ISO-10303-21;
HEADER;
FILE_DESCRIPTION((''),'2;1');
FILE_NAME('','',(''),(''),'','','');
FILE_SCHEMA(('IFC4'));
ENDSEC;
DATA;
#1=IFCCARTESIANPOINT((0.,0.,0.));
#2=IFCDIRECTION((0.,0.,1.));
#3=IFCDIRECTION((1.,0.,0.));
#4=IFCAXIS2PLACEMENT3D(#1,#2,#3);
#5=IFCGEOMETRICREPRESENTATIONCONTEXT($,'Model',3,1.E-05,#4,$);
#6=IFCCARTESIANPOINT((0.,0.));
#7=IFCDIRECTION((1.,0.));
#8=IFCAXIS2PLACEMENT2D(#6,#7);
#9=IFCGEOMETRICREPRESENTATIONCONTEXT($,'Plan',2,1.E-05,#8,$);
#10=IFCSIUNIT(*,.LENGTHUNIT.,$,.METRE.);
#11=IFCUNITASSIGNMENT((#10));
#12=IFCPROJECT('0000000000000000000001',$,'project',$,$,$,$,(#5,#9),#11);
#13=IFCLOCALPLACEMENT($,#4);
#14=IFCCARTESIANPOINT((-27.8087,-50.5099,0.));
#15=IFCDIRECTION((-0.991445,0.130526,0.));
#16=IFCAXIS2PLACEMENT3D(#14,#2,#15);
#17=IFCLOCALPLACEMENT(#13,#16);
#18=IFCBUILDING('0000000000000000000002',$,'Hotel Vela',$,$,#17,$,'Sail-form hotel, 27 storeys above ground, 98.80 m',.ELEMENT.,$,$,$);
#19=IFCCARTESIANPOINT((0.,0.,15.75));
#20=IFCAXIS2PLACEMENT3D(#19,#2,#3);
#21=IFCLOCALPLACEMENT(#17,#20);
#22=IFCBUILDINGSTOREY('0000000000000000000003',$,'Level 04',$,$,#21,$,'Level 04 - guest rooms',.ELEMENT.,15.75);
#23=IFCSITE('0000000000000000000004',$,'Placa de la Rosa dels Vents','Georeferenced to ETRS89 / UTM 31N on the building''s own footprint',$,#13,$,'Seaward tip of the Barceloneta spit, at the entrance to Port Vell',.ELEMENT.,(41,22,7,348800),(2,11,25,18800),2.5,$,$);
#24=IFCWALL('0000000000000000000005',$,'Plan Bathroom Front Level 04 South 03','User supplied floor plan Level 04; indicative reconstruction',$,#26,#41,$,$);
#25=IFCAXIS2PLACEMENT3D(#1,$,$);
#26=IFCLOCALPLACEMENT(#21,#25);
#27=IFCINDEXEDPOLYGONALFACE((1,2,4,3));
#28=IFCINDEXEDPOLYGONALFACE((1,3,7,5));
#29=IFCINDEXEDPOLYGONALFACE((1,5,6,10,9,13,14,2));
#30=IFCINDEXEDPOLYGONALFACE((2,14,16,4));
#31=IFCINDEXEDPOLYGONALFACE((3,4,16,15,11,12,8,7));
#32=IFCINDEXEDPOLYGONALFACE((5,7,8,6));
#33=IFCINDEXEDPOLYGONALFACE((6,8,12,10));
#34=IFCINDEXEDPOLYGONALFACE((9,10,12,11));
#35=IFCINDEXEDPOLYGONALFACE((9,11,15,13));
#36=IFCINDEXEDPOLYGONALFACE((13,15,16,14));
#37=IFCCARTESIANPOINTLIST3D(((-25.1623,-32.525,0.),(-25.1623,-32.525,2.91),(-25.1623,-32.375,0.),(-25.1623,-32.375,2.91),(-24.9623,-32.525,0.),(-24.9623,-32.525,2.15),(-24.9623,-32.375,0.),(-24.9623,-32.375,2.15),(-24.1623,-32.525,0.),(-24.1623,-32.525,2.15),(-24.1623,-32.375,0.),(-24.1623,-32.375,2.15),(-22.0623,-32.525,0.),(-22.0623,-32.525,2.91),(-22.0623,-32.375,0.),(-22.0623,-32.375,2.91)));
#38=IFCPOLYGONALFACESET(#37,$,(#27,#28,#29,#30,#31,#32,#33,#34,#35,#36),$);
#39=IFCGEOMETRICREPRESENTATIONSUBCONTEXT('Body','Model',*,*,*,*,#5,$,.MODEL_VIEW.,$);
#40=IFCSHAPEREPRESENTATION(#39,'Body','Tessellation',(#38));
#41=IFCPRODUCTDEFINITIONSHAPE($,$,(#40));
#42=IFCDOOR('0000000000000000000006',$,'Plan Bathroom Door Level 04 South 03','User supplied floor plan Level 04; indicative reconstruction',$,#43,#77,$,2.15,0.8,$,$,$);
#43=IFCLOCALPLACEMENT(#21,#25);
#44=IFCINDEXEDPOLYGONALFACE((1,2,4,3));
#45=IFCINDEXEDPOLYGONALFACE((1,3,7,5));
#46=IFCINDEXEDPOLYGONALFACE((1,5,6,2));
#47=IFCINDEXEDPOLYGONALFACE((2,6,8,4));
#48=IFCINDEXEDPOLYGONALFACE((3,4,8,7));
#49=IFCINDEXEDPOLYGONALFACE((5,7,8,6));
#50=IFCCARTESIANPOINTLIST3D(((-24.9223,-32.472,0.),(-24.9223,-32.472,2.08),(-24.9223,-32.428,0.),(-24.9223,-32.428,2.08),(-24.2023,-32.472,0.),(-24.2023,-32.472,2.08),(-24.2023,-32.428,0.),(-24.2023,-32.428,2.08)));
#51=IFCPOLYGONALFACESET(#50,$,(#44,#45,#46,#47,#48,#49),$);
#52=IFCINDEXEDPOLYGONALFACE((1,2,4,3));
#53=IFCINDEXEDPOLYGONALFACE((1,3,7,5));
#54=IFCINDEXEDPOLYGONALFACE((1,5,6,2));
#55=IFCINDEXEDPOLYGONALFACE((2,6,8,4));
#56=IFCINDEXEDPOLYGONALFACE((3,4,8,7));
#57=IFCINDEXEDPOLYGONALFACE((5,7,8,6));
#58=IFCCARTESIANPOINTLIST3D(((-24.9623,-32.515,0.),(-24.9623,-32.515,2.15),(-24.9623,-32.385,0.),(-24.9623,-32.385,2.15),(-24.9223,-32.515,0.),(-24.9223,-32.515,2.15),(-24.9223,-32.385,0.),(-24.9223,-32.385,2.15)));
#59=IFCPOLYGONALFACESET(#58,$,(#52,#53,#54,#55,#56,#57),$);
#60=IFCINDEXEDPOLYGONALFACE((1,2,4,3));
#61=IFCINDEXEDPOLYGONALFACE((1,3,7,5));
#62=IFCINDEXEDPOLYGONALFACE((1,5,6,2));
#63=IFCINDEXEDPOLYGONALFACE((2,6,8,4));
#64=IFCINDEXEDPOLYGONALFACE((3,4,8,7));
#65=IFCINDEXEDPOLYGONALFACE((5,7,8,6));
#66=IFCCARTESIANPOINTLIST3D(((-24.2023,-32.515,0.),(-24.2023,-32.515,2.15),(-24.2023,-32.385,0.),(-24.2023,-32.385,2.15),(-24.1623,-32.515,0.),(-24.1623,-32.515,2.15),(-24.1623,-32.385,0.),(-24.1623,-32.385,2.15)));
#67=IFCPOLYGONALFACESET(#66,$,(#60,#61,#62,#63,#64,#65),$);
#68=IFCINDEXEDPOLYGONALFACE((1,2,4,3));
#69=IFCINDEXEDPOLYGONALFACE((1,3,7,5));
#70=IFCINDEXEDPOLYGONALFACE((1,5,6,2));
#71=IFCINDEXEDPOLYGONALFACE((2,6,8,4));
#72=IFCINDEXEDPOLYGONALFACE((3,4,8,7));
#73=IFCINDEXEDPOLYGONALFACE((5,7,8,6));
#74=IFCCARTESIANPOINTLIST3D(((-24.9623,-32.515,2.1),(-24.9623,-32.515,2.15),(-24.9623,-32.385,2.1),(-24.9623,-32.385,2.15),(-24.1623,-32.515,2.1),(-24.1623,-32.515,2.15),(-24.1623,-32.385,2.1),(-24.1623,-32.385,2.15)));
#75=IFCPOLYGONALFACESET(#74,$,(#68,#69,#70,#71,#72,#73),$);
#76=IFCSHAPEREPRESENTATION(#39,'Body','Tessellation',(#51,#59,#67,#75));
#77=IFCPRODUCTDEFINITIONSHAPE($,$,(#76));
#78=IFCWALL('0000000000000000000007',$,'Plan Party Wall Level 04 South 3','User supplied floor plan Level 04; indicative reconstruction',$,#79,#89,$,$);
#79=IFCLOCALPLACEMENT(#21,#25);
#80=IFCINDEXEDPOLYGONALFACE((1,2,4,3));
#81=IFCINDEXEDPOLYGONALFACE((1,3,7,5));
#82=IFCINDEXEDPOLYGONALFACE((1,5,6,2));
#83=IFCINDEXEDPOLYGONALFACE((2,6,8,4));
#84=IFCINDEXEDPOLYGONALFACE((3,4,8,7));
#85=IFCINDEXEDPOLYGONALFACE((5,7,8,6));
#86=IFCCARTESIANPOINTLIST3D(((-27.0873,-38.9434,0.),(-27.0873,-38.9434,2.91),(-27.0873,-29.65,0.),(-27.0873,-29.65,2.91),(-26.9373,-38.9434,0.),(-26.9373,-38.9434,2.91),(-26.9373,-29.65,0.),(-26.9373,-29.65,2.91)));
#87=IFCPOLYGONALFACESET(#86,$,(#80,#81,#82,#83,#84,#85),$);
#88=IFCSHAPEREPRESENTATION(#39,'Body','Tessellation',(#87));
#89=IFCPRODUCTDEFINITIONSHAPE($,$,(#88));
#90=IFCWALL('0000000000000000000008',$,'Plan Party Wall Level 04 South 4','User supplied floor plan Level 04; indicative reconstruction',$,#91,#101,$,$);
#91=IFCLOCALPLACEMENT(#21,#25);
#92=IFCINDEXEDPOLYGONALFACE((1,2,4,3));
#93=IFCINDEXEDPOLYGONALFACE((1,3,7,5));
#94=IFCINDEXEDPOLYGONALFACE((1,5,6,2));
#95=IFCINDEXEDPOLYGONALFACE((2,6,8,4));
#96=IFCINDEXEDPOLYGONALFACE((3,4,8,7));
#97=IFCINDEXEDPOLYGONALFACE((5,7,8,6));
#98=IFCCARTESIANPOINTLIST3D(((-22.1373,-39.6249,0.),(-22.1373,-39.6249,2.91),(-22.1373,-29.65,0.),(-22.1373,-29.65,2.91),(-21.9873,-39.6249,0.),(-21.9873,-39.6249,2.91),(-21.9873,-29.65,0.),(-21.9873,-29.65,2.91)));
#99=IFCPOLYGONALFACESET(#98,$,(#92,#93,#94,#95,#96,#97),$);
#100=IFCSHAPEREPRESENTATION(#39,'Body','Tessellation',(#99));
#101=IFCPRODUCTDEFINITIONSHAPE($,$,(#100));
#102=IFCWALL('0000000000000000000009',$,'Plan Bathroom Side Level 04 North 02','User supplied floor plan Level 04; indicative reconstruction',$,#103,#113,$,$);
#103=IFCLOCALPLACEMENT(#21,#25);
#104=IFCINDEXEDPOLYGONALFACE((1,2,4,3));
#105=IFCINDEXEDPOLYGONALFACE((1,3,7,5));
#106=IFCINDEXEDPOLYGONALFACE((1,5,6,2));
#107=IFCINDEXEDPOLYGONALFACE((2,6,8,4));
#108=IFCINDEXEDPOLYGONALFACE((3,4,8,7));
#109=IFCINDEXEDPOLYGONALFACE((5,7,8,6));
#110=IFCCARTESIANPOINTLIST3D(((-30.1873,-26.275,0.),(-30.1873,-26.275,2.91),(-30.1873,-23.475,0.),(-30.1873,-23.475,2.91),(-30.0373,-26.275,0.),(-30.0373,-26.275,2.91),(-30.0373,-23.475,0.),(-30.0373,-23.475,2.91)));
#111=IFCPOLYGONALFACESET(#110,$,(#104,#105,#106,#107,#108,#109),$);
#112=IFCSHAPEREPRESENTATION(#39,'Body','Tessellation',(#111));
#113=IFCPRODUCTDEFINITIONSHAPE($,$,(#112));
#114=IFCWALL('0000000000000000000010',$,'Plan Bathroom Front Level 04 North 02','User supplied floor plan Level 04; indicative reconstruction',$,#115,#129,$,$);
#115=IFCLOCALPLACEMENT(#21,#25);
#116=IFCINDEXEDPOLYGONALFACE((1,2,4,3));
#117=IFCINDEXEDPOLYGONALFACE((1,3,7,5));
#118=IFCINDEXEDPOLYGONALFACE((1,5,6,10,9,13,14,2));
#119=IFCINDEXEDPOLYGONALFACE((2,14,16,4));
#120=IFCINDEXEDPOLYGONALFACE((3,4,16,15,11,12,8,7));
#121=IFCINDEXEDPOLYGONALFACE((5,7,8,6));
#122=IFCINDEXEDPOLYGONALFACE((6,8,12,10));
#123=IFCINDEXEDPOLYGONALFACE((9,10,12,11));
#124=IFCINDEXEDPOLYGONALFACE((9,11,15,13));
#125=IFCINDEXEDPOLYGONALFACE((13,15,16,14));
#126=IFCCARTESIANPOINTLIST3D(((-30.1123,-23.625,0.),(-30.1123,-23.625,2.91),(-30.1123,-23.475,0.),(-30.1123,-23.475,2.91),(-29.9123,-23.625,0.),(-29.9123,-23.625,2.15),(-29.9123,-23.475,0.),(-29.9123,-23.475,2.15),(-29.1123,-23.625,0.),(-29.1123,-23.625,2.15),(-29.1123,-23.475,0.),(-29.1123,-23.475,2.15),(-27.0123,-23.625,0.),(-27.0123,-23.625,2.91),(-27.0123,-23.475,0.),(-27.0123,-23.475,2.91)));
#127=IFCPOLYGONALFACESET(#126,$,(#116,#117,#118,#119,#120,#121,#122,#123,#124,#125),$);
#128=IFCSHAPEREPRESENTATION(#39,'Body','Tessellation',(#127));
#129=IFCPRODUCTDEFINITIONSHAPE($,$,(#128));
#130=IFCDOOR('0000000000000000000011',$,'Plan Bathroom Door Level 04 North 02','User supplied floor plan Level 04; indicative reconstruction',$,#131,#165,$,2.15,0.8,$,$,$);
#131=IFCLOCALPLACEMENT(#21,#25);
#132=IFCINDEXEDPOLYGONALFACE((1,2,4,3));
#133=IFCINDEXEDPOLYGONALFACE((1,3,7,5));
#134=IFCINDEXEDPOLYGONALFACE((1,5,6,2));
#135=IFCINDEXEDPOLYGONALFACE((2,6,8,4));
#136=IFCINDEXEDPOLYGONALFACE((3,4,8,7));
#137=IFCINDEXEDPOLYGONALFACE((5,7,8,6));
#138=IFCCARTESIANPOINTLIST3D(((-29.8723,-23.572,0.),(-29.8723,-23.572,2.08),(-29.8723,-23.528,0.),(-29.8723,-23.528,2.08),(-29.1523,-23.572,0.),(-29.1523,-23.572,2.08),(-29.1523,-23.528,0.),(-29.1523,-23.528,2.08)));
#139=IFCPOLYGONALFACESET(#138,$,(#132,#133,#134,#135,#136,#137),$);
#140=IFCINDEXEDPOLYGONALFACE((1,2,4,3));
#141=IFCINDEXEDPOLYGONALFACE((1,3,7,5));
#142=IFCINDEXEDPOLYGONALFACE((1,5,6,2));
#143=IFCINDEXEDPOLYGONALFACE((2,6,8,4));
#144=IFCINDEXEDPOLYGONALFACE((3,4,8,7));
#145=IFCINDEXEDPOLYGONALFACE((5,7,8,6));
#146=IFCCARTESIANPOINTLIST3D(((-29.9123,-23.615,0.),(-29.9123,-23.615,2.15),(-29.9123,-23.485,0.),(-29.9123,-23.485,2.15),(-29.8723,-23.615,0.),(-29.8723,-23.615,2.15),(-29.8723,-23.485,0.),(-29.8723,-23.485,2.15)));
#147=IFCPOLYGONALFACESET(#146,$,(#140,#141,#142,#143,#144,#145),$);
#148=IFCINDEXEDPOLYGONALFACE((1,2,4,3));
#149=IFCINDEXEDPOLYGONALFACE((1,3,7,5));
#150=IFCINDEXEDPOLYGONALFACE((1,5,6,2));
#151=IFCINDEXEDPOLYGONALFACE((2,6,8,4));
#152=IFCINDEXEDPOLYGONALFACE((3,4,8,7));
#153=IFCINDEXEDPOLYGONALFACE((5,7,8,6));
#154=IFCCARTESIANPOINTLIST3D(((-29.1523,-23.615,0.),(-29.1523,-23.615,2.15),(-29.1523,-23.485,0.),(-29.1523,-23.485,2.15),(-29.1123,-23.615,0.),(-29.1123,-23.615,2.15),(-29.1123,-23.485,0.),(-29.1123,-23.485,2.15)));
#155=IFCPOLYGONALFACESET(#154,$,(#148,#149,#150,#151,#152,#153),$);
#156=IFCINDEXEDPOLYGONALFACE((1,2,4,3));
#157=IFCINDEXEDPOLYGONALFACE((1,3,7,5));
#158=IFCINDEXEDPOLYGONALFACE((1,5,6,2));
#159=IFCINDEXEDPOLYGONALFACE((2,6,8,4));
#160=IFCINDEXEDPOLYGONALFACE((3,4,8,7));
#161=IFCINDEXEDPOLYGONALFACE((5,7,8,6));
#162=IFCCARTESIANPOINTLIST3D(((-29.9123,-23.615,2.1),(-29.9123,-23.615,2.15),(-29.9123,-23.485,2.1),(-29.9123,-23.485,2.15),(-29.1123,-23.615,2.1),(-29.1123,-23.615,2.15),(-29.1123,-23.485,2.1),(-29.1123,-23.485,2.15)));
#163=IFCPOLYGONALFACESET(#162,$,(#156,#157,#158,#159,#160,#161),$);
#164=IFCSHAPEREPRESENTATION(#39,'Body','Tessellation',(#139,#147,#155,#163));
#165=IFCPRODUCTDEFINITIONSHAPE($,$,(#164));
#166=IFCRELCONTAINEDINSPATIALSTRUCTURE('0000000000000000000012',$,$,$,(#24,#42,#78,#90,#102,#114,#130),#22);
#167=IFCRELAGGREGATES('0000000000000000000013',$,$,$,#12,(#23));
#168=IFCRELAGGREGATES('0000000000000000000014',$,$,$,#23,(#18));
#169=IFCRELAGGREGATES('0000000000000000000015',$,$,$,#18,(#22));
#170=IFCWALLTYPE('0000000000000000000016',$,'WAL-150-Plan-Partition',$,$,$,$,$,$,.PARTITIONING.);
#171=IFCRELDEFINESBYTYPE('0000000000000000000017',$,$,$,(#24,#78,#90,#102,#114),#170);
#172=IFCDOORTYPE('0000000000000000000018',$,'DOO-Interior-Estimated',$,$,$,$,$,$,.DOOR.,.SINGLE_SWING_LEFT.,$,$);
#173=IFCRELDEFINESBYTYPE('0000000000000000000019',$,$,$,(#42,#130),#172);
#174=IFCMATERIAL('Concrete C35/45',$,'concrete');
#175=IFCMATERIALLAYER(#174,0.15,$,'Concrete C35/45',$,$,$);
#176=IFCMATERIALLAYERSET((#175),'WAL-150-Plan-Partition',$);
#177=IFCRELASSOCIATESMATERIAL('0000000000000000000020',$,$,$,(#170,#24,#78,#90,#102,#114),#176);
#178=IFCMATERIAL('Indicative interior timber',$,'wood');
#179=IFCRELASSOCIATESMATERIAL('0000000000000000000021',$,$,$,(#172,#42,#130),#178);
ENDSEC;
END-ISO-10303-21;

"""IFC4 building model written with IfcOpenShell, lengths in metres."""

from ifc_helpers import new_model, si_unit, frame, origin_with_axes, origin_2d_with_axis, place, context, subcontext, project, spatial, line, indexed_curve, outline, extrude, material, layer, layer_set, layer_usage, type_object, element, fill, save


model = new_model("IFC4")

# Units and contexts
model_context = context("Model", 3, precision=1e-05, world=origin_with_axes())
plan_context = context("Plan", 2, precision=1e-05, world=origin_2d_with_axis())
body_context = subcontext(model_context, "Body", "Model", "MODEL_VIEW")
ifc_project = project(units=[si_unit("LENGTHUNIT", "METRE")], contexts=[model_context, plan_context])

# Site, building, storey
site_placement = place(None, origin_with_axes())
site = spatial("IfcSite", under=ifc_project, at=site_placement, Name="Placa de la Rosa dels Vents", Description="Georeferenced to ETRS89 / UTM 31N on the building's own footprint", LongName="Seaward tip of the Barceloneta spit, at the entrance to Port Vell", CompositionType="ELEMENT", RefLatitude=(41, 22, 7, 348800), RefLongitude=(2, 11, 25, 18800), RefElevation=2.5)
building_placement = place(site_placement, frame((-27.8087, -50.5099, 0.0), z_axis=(0.0, 0.0, 1.0), x_axis=(-0.991445, 0.130526, 0.0)))
building = spatial("IfcBuilding", under=site, at=building_placement, Name="Hotel Vela", LongName="Sail-form hotel, 27 storeys above ground, 98.80 m", CompositionType="ELEMENT")
storey_placement = place(building_placement, frame((0.0, 0.0, 15.75), z_axis=(0.0, 0.0, 1.0), x_axis=(1.0, 0.0, 0.0)))
storey = spatial("IfcBuildingStorey", under=building, at=storey_placement, Name="Level 04", LongName="Level 04 - guest rooms", CompositionType="ELEMENT", Elevation=15.75)

# Shared definitions
ifc_material_1 = material(Name="Concrete C35/45", Category="concrete")
ifc_layer = layer(ifc_material_1, 0.15, Name="Concrete C35/45")
ifc_layer_set = layer_set([ifc_layer], Name="WAL-150-Plan-Partition")
wall_type = type_object("IfcWallType", Name="WAL-150-Plan-Partition", PredefinedType="PARTITIONING", material=ifc_layer_set)

# Shared definitions
ifc_material_2 = material(Name="Indicative interior timber", Category="wood")
door_type = type_object("IfcDoorType", Name="DOO-Interior-Estimated", OperationType="SINGLE_SWING_LEFT", PredefinedType="DOOR", material=ifc_material_2)

# Wall, opening, door
ifc_layer_usage_1 = layer_usage(ifc_layer_set, "AXIS2", "POSITIVE", 0.0)
wall_1_placement = place(storey_placement, frame((-25.1623, -32.525, 0.0), z_axis=(0.0, 0.0, 1.0), x_axis=(1.0, 0.0, 0.0)))
wall_1 = element("IfcWall", 1, at=wall_1_placement, inside=storey, type_object=wall_type, material=ifc_layer_usage_1, Name="Plan Bathroom Front Level 04 South 03", Description="User supplied floor plan Level 04; indicative reconstruction", context=body_context, shape_type="SweptSolid", body=[
    extrude(outline(indexed_curve([(0.0, 0.0), (3.1, 0.0), (3.1, 0.15), (0.0, 0.15)], segments=[line(1, 2, 3, 4, 1)])), origin_with_axes(), (0.0, 0.0, 1.0), 2.91),
])
opening_1_placement = place(wall_1_placement, frame((0.2, -0.085, 0.0), z_axis=(0.0, 0.0, 1.0), x_axis=(1.0, 0.0, 0.0)))
opening_1 = element("IfcOpeningElement", 2, at=opening_1_placement, cuts=wall_1, PredefinedType="OPENING", context=body_context, shape_type="SweptSolid", body=[
    extrude(outline(indexed_curve([(0.0, 0.0), (0.8, 0.0), (0.8, 0.32), (0.0, 0.32)], segments=[line(1, 2, 3, 4, 1)])), origin_with_axes(), (0.0, 0.0, 1.0), 2.15),
])
door_1_placement = place(storey_placement, frame((0.0, 0.0, -15.75), z_axis=(0.0, 0.0, 1.0), x_axis=(1.0, 0.0, 0.0)))
door_1 = element("IfcDoor", 3, at=door_1_placement, inside=storey, type_object=door_type, material=ifc_material_2, Name="Plan Bathroom Door Level 04 South 03", Description="User supplied floor plan Level 04; indicative reconstruction", OverallHeight=2.15, OverallWidth=0.8, context=body_context, shape_type="SweptSolid", body=[
    extrude(outline(indexed_curve([(0.0, 0.0), (0.72, 0.0), (0.72, 0.044), (0.0, 0.044)], segments=[line(1, 2, 3, 4, 1)])), frame((-24.9223, -32.472, 15.75), z_axis=(0.0, 0.0, 1.0), x_axis=(1.0, 0.0, 0.0)), (0.0, 0.0, 1.0), 2.08),
    extrude(outline(indexed_curve([(0.0, 0.0), (0.04, 0.0), (0.04, 0.13), (0.0, 0.13)], segments=[line(1, 2, 3, 4, 1)])), frame((-24.9623, -32.515, 15.75), z_axis=(0.0, 0.0, 1.0), x_axis=(1.0, 0.0, 0.0)), (0.0, 0.0, 1.0), 2.15),
    extrude(outline(indexed_curve([(0.0, 0.0), (0.04, 0.0), (0.04, 0.13), (0.0, 0.13)], segments=[line(1, 2, 3, 4, 1)])), frame((-24.2023, -32.515, 15.75), z_axis=(0.0, 0.0, 1.0), x_axis=(1.0, 0.0, 0.0)), (0.0, 0.0, 1.0), 2.15),
    extrude(outline(indexed_curve([(0.0, 0.0), (0.8, 0.0), (0.8, 0.13), (0.0, 0.13)], segments=[line(1, 2, 3, 4, 1)])), frame((-24.9623, -32.515, 17.85), z_axis=(0.0, 0.0, 1.0), x_axis=(1.0, 0.0, 0.0)), (0.0, 0.0, 1.0), 0.05),
])
fill(opening_1, door_1)

# Walls
ifc_layer_usage_2 = layer_usage(ifc_layer_set, "AXIS2", "POSITIVE", 0.0)
wall_2_placement = place(storey_placement, frame((-27.0873, -38.9434, 0.0), z_axis=(0.0, 0.0, 1.0), x_axis=(1.0, 0.0, 0.0)))
element("IfcWall", 4, at=wall_2_placement, inside=storey, type_object=wall_type, material=ifc_layer_usage_2, Name="Plan Party Wall Level 04 South 3", Description="User supplied floor plan Level 04; indicative reconstruction", context=body_context, shape_type="SweptSolid", body=[
    extrude(outline(indexed_curve([(0.0, 0.0), (0.15, 0.0), (0.15, 9.2934), (0.0, 9.2934)], segments=[line(1, 2, 3, 4, 1)])), origin_with_axes(), (0.0, 0.0, 1.0), 2.91),
])
ifc_layer_usage_3 = layer_usage(ifc_layer_set, "AXIS2", "POSITIVE", 0.0)
wall_3_placement = place(storey_placement, frame((-22.1373, -39.6249, 0.0), z_axis=(0.0, 0.0, 1.0), x_axis=(1.0, 0.0, 0.0)))
element("IfcWall", 5, at=wall_3_placement, inside=storey, type_object=wall_type, material=ifc_layer_usage_3, Name="Plan Party Wall Level 04 South 4", Description="User supplied floor plan Level 04; indicative reconstruction", context=body_context, shape_type="SweptSolid", body=[
    extrude(outline(indexed_curve([(0.0, 0.0), (0.15, 0.0), (0.15, 9.9749), (0.0, 9.9749)], segments=[line(1, 2, 3, 4, 1)])), origin_with_axes(), (0.0, 0.0, 1.0), 2.91),
])
ifc_layer_usage_4 = layer_usage(ifc_layer_set, "AXIS2", "POSITIVE", 0.0)
wall_4_placement = place(storey_placement, frame((-30.1873, -26.275, 0.0), z_axis=(0.0, 0.0, 1.0), x_axis=(1.0, 0.0, 0.0)))
element("IfcWall", 6, at=wall_4_placement, inside=storey, type_object=wall_type, material=ifc_layer_usage_4, Name="Plan Bathroom Side Level 04 North 02", Description="User supplied floor plan Level 04; indicative reconstruction", context=body_context, shape_type="SweptSolid", body=[
    extrude(outline(indexed_curve([(0.0, 0.0), (0.15, 0.0), (0.15, 2.8), (0.0, 2.8)], segments=[line(1, 2, 3, 4, 1)])), origin_with_axes(), (0.0, 0.0, 1.0), 2.91),
])

# Wall, opening, door
ifc_layer_usage_5 = layer_usage(ifc_layer_set, "AXIS2", "POSITIVE", 0.0)
wall_5_placement = place(storey_placement, frame((-30.1123, -23.625, 0.0), z_axis=(0.0, 0.0, 1.0), x_axis=(1.0, 0.0, 0.0)))
wall_5 = element("IfcWall", 7, at=wall_5_placement, inside=storey, type_object=wall_type, material=ifc_layer_usage_5, Name="Plan Bathroom Front Level 04 North 02", Description="User supplied floor plan Level 04; indicative reconstruction", context=body_context, shape_type="SweptSolid", body=[
    extrude(outline(indexed_curve([(0.0, 0.0), (3.1, 0.0), (3.1, 0.15), (0.0, 0.15)], segments=[line(1, 2, 3, 4, 1)])), origin_with_axes(), (0.0, 0.0, 1.0), 2.91),
])
opening_2_placement = place(wall_5_placement, frame((0.2, -0.085, 0.0), z_axis=(0.0, 0.0, 1.0), x_axis=(1.0, 0.0, 0.0)))
opening_2 = element("IfcOpeningElement", 8, at=opening_2_placement, cuts=wall_5, PredefinedType="OPENING", context=body_context, shape_type="SweptSolid", body=[
    extrude(outline(indexed_curve([(0.0, 0.0), (0.8, 0.0), (0.8, 0.32), (0.0, 0.32)], segments=[line(1, 2, 3, 4, 1)])), origin_with_axes(), (0.0, 0.0, 1.0), 2.15),
])
door_2_placement = place(storey_placement, frame((0.0, 0.0, -15.75), z_axis=(0.0, 0.0, 1.0), x_axis=(1.0, 0.0, 0.0)))
door_2 = element("IfcDoor", 9, at=door_2_placement, inside=storey, type_object=door_type, material=ifc_material_2, Name="Plan Bathroom Door Level 04 North 02", Description="User supplied floor plan Level 04; indicative reconstruction", OverallHeight=2.15, OverallWidth=0.8, context=body_context, shape_type="SweptSolid", body=[
    extrude(outline(indexed_curve([(0.0, 0.0), (0.72, 0.0), (0.72, 0.044), (0.0, 0.044)], segments=[line(1, 2, 3, 4, 1)])), frame((-29.8723, -23.572, 15.75), z_axis=(0.0, 0.0, 1.0), x_axis=(1.0, 0.0, 0.0)), (0.0, 0.0, 1.0), 2.08),
    extrude(outline(indexed_curve([(0.0, 0.0), (0.04, 0.0), (0.04, 0.13), (0.0, 0.13)], segments=[line(1, 2, 3, 4, 1)])), frame((-29.9123, -23.615, 15.75), z_axis=(0.0, 0.0, 1.0), x_axis=(1.0, 0.0, 0.0)), (0.0, 0.0, 1.0), 2.15),
    extrude(outline(indexed_curve([(0.0, 0.0), (0.04, 0.0), (0.04, 0.13), (0.0, 0.13)], segments=[line(1, 2, 3, 4, 1)])), frame((-29.1523, -23.615, 15.75), z_axis=(0.0, 0.0, 1.0), x_axis=(1.0, 0.0, 0.0)), (0.0, 0.0, 1.0), 2.15),
    extrude(outline(indexed_curve([(0.0, 0.0), (0.8, 0.0), (0.8, 0.13), (0.0, 0.13)], segments=[line(1, 2, 3, 4, 1)])), frame((-29.9123, -23.615, 17.85), z_axis=(0.0, 0.0, 1.0), x_axis=(1.0, 0.0, 0.0)), (0.0, 0.0, 1.0), 0.05),
])
fill(opening_2, door_2)

save(model, "model.ifc")
